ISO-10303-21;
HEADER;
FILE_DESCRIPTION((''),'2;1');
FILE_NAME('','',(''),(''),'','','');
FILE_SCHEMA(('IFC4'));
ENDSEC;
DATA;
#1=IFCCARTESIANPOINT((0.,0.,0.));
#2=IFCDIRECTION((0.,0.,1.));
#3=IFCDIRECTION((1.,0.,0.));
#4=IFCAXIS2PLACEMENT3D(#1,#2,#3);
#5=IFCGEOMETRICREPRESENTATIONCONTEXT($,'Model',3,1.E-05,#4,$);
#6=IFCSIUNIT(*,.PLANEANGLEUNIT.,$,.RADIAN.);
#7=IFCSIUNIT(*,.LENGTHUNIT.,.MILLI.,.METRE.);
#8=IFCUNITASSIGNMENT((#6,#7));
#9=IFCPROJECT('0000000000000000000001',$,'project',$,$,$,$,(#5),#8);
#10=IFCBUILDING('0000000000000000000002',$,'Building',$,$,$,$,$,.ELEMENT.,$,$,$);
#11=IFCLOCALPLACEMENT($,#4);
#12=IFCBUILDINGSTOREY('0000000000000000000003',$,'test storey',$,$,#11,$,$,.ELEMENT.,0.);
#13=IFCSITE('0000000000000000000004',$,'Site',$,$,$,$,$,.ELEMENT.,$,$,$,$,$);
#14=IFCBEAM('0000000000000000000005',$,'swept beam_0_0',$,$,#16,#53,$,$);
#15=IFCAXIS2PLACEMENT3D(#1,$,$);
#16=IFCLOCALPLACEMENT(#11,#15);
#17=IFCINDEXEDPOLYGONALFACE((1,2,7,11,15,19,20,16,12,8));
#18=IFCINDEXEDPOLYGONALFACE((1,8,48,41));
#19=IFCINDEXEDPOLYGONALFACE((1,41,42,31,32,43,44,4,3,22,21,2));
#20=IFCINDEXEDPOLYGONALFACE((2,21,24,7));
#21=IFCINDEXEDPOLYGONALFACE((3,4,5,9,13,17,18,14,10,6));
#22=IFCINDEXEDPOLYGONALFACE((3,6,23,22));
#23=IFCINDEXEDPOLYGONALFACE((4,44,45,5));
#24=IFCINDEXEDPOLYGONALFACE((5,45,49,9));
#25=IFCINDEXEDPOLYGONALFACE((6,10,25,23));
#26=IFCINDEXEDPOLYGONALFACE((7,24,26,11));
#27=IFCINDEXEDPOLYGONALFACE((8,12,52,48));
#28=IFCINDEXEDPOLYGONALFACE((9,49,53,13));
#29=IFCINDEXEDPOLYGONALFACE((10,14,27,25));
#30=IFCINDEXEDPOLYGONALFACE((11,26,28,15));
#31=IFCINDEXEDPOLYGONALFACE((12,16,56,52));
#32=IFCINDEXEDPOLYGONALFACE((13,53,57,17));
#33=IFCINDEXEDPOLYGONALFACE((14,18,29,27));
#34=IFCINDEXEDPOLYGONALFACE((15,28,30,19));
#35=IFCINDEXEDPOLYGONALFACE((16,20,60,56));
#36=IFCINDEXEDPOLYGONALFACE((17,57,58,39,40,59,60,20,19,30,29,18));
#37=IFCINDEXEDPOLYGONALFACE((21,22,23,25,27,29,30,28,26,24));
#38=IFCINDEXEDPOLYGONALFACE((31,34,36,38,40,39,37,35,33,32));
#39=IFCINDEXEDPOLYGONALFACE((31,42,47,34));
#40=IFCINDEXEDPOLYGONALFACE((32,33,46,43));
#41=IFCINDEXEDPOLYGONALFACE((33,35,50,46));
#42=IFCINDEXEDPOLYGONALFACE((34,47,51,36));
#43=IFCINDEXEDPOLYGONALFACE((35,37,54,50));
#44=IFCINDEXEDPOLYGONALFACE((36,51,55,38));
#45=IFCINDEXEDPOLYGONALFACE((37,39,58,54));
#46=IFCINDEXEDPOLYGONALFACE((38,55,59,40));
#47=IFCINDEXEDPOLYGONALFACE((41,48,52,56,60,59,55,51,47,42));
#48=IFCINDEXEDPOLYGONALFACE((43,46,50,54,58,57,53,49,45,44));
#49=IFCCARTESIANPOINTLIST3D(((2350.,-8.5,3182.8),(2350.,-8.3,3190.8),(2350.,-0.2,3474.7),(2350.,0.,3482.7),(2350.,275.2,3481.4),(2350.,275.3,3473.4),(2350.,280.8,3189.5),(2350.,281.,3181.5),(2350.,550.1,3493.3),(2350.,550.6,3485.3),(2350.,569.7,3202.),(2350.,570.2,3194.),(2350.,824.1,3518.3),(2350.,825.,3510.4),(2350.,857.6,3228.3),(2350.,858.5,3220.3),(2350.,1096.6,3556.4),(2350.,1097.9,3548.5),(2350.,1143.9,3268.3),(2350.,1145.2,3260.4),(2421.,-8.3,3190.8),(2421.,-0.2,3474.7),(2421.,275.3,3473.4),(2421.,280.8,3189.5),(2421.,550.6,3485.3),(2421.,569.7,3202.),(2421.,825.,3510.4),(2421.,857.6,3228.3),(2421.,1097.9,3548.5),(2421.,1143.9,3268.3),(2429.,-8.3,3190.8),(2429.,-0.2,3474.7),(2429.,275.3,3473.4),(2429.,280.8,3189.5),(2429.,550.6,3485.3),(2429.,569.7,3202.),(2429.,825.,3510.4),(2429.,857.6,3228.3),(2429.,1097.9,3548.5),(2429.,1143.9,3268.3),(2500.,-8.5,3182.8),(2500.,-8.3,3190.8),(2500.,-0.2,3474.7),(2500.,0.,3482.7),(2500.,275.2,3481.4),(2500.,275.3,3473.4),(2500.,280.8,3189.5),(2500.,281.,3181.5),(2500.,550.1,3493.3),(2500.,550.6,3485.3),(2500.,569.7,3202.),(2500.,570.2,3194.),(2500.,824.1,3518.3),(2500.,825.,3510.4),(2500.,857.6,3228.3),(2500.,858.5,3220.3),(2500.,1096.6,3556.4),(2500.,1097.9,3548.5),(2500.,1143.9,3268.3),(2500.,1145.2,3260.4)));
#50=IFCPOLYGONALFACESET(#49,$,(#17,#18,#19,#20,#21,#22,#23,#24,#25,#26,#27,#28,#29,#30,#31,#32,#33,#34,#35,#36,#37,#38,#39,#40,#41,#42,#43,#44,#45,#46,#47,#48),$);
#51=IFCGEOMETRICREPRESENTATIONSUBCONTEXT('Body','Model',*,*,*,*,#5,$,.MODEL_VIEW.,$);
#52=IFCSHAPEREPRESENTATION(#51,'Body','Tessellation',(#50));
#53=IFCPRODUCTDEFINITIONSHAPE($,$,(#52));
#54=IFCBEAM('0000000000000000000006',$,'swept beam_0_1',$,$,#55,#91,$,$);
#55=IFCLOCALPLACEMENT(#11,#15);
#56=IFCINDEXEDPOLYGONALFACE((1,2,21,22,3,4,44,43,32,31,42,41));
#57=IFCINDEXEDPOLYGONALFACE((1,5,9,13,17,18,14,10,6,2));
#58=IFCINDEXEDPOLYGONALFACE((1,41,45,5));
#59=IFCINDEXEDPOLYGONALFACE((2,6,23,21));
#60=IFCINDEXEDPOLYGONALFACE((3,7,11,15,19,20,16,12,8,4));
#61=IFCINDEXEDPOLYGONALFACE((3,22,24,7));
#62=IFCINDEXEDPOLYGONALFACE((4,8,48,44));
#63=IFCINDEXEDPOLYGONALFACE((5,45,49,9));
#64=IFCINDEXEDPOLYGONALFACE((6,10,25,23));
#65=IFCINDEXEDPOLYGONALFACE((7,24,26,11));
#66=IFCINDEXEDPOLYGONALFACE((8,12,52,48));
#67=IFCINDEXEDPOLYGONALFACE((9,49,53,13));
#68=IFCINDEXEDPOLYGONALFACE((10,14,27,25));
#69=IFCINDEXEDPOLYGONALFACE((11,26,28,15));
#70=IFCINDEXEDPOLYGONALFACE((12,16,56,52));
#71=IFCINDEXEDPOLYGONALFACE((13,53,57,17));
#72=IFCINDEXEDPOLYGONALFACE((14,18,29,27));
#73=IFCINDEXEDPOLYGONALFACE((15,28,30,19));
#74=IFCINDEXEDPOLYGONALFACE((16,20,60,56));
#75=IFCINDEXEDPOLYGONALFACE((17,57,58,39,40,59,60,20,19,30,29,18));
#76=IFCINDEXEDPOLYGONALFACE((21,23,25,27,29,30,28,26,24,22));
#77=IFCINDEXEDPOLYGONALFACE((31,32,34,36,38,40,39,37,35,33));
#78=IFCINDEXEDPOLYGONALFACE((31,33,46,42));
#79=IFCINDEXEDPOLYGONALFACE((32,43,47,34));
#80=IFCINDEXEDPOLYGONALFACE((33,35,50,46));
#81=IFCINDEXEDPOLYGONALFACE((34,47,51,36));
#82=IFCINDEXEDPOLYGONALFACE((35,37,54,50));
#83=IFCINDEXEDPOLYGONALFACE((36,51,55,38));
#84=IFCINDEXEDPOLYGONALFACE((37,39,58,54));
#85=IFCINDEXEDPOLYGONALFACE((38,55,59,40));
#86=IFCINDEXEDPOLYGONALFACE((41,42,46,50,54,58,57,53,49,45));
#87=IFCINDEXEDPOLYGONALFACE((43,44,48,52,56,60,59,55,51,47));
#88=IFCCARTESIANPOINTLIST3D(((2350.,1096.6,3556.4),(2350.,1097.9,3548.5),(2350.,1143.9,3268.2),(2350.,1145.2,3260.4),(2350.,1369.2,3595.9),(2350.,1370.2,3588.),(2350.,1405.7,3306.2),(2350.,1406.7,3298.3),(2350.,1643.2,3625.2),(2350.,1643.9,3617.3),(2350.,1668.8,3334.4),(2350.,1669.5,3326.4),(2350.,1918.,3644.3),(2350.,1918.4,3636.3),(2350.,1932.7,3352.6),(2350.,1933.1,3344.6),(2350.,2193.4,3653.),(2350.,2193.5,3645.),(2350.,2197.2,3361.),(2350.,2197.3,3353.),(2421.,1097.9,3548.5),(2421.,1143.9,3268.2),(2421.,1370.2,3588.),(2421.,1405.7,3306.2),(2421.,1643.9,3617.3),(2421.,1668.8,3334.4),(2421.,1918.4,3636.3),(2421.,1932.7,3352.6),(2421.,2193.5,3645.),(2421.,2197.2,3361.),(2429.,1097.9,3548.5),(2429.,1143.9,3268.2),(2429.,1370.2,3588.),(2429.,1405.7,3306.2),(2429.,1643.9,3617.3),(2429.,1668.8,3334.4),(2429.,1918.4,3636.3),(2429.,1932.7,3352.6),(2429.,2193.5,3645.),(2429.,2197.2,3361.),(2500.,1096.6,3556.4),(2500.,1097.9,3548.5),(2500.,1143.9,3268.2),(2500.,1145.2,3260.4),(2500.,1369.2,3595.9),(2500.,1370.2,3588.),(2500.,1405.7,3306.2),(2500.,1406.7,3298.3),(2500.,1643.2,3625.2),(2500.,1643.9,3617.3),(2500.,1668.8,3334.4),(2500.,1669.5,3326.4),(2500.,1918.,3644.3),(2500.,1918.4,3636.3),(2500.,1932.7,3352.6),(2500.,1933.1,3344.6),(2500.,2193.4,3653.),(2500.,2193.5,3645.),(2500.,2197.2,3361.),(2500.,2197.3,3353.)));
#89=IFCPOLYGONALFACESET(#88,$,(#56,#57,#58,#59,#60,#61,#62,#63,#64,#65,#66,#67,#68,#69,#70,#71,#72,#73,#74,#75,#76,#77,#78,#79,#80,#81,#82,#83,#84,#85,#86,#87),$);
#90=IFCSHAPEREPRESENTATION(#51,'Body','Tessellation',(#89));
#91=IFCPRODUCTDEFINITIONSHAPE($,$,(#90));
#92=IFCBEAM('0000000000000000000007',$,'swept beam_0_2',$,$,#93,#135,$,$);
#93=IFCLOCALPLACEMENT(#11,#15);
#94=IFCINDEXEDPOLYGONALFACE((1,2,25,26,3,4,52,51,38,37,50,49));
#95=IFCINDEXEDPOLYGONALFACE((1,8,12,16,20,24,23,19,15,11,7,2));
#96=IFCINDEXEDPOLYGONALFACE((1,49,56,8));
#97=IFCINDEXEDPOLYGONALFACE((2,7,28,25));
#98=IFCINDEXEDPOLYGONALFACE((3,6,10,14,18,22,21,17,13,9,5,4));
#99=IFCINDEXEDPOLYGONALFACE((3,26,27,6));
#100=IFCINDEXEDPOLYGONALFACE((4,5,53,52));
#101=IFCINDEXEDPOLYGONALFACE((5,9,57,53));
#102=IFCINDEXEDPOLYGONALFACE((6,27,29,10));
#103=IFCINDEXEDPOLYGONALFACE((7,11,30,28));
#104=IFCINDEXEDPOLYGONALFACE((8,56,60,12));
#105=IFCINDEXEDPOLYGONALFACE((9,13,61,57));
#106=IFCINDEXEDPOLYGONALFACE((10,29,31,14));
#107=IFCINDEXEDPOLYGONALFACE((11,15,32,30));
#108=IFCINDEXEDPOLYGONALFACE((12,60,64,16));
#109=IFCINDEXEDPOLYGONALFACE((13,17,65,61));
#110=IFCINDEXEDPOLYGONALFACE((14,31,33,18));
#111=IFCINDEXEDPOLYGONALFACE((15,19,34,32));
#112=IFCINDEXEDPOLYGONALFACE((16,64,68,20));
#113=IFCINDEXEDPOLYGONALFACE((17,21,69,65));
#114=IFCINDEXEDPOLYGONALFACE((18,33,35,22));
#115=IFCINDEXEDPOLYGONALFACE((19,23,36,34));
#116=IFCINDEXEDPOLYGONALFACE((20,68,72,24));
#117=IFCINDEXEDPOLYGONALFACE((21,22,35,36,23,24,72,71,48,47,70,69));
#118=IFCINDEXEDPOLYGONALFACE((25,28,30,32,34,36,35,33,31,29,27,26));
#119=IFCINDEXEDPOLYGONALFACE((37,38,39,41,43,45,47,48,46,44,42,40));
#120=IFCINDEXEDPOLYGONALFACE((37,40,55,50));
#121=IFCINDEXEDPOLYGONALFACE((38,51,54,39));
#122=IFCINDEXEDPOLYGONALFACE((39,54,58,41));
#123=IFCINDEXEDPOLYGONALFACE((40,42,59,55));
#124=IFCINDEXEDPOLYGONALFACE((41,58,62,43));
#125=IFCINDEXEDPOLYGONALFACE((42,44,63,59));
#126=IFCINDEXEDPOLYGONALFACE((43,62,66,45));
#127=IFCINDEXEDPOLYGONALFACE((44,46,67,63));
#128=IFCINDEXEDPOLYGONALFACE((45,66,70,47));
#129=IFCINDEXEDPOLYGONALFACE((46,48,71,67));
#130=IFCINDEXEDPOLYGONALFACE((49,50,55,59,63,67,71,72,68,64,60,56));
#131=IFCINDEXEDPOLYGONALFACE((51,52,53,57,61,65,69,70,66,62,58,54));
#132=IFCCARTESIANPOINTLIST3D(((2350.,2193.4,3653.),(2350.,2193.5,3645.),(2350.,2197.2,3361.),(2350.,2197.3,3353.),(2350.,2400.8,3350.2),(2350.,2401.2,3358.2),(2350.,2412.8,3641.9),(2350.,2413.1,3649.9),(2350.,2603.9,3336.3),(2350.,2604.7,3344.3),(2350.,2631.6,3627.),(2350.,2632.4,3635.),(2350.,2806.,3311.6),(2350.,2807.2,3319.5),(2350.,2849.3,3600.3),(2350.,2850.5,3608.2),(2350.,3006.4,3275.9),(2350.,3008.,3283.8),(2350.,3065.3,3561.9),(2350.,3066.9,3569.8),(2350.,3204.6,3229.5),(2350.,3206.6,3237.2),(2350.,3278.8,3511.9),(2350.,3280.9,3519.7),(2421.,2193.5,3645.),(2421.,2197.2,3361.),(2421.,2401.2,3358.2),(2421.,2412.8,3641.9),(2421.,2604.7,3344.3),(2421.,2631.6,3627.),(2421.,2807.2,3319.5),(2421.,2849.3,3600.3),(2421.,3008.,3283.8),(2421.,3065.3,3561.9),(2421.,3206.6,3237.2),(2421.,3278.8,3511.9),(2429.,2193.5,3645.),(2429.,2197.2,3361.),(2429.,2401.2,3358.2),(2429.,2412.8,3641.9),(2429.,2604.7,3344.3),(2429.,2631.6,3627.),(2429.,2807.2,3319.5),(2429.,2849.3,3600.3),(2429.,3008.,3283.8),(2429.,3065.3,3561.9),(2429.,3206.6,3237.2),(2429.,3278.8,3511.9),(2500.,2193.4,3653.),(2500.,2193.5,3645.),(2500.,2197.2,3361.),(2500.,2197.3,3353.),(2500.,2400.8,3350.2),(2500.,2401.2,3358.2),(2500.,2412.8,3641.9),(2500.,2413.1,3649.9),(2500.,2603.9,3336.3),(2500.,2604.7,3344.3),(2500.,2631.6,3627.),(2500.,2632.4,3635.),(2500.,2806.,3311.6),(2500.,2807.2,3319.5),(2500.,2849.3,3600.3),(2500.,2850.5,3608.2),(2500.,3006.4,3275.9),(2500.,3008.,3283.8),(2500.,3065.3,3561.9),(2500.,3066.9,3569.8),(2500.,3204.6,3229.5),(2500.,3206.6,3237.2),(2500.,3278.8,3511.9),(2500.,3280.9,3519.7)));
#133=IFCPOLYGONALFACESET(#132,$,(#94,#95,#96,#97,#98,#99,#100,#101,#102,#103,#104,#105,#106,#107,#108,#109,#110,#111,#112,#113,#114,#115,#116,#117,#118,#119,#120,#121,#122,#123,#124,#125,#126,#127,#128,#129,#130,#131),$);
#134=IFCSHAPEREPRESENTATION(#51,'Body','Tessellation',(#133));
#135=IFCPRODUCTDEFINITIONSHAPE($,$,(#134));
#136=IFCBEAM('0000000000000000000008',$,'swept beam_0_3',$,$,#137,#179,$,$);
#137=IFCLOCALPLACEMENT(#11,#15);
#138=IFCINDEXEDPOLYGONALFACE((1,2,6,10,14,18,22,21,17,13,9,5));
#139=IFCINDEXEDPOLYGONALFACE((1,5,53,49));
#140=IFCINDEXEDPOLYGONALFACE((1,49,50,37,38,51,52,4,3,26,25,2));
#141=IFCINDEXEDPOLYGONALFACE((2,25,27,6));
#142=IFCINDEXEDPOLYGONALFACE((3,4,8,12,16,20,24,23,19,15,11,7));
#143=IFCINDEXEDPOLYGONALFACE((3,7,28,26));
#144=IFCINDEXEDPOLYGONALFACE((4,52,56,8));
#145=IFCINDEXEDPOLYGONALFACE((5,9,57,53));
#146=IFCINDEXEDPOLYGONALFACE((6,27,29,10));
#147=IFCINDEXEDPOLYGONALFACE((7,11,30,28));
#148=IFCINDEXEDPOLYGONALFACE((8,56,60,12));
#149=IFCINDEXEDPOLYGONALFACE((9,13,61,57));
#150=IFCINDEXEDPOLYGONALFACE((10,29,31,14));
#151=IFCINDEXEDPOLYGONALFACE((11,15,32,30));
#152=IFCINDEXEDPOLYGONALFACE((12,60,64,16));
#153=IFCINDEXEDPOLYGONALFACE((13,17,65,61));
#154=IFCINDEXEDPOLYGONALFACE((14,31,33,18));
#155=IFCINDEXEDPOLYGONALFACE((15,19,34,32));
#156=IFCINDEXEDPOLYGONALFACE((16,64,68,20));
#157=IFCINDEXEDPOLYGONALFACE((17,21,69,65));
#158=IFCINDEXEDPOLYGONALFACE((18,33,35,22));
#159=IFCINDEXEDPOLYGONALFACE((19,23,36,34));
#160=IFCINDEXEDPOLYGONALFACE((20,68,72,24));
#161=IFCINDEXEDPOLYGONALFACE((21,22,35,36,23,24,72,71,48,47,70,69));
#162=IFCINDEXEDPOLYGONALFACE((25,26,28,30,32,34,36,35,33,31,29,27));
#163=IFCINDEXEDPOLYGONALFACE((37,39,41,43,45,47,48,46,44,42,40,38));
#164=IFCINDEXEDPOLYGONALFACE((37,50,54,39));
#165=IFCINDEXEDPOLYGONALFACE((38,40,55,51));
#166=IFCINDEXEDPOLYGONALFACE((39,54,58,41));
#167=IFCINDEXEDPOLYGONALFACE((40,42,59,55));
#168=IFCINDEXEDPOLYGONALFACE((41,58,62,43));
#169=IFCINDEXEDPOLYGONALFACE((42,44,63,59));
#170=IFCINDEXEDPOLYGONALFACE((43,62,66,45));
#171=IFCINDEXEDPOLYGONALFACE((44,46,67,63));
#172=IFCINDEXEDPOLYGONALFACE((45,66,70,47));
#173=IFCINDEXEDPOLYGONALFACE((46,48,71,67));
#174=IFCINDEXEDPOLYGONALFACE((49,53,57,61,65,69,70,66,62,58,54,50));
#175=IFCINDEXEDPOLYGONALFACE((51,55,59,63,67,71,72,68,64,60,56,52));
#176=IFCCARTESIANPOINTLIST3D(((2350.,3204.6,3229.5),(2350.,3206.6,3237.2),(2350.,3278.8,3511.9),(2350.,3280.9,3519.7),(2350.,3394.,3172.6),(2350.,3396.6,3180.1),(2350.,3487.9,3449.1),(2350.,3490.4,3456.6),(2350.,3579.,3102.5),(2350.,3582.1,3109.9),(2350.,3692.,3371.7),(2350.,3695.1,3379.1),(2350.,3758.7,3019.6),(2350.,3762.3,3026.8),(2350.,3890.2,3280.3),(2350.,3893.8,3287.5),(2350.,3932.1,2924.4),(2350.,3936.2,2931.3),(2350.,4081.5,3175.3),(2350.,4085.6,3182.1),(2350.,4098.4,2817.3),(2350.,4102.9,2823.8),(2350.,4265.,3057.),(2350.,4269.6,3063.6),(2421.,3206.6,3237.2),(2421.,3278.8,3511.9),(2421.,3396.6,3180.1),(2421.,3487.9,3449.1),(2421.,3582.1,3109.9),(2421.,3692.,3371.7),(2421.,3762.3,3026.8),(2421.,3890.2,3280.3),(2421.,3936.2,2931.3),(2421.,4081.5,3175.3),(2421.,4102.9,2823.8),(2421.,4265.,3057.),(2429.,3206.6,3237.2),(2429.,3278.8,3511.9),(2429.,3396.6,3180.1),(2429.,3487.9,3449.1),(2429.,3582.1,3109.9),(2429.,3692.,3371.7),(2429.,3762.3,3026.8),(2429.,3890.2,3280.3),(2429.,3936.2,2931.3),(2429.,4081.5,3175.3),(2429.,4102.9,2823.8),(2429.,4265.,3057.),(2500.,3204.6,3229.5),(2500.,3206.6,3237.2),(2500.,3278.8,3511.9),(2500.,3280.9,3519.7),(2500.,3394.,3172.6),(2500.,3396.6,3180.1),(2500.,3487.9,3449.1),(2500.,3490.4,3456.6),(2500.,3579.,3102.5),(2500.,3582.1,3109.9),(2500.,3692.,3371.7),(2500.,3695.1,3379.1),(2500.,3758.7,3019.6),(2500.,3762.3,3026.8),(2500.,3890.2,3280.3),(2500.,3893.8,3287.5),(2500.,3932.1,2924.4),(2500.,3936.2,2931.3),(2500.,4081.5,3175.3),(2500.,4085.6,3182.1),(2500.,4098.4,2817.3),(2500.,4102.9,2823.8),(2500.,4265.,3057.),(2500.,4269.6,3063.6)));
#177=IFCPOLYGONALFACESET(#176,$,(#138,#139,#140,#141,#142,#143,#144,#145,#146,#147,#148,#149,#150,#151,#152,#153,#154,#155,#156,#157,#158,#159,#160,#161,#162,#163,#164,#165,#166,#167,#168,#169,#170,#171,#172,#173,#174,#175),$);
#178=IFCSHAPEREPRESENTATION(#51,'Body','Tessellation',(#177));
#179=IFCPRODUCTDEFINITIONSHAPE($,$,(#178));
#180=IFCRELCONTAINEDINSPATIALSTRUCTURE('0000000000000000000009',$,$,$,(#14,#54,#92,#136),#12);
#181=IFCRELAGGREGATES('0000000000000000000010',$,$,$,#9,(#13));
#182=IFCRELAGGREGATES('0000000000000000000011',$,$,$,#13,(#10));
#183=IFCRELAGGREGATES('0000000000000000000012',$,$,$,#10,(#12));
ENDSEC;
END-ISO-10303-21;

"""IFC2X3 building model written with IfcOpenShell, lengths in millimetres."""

from ifc_helpers import new_model, entity, si_unit, origin_with_axes, place, context, subcontext, project, spatial, element, save


model = new_model("IFC2X3")

# Units and contexts
model_context = context("Model", 3, precision=1e-05, world=origin_with_axes())
body_context = subcontext(model_context, "Body", "Model", "MODEL_VIEW")
ifc_project = project(units=[si_unit("PLANEANGLEUNIT", "RADIAN"), si_unit("LENGTHUNIT", "METRE", prefix="MILLI")], contexts=[model_context])

# Site, building, storey
site = spatial("IfcSite", under=ifc_project, Name="Site", CompositionType="ELEMENT")
building = spatial("IfcBuilding", under=site, Name="Building", CompositionType="ELEMENT")
storey_placement = place(None, origin_with_axes())
storey = spatial("IfcBuildingStorey", under=building, at=storey_placement, Name="test storey", CompositionType="ELEMENT", Elevation=0.0)

# Beams
beam_1_placement = place(storey_placement, origin_with_axes())
element("IfcBeam", 1, at=beam_1_placement, inside=storey, Name="swept beam_0_0", context=body_context, shape_type="SweptSolid", body=[
    entity("IfcRevolvedAreaSolid", entity("IfcArbitraryClosedProfileDef", "AREA", None, entity("IfcPolyline", [entity("IfcCartesianPoint", [292.0, 0.0]), entity("IfcCartesianPoint", [292.0, -71.0]), entity("IfcCartesianPoint", [8.0, -71.0]), entity("IfcCartesianPoint", [8.0, 0.0]), entity("IfcCartesianPoint", [0.0, 0.0]), entity("IfcCartesianPoint", [0.0, -150.0]), entity("IfcCartesianPoint", [8.0, -150.0]), entity("IfcCartesianPoint", [8.0, -79.0]), entity("IfcCartesianPoint", [292.0, -79.0]), entity("IfcCartesianPoint", [292.0, -150.0]), entity("IfcCartesianPoint", [300.0, -150.0]), entity("IfcCartesianPoint", [300.0, 0.0]), entity("IfcCartesianPoint", [292.0, 0.0])])), entity("IfcAxis2Placement3D", entity("IfcCartesianPoint", [2500.0, 0.0, 3482.7]), entity("IfcDirection", [0.0, -0.9996, 0.0284]), entity("IfcDirection", [0.0, -0.0284, -0.9996])), entity("IfcAxis1Placement", entity("IfcCartesianPoint", [-5757.9, 0.0, 0.0]), entity("IfcDirection", [0.0, 1.0, 0.0])), 0.191172),
])
beam_2_placement = place(storey_placement, origin_with_axes())
element("IfcBeam", 2, at=beam_2_placement, inside=storey, Name="swept beam_0_1", context=body_context, shape_type="SweptSolid", body=[
    entity("IfcRevolvedAreaSolid", entity("IfcArbitraryClosedProfileDef", "AREA", None, entity("IfcPolyline", [entity("IfcCartesianPoint", [-292.0, 0.0]), entity("IfcCartesianPoint", [-292.0, 71.0]), entity("IfcCartesianPoint", [-8.0, 71.0]), entity("IfcCartesianPoint", [-8.0, 0.0]), entity("IfcCartesianPoint", [0.0, 0.0]), entity("IfcCartesianPoint", [0.0, 150.0]), entity("IfcCartesianPoint", [-8.0, 150.0]), entity("IfcCartesianPoint", [-8.0, 79.0]), entity("IfcCartesianPoint", [-292.0, 79.0]), entity("IfcCartesianPoint", [-292.0, 150.0]), entity("IfcCartesianPoint", [-300.0, 150.0]), entity("IfcCartesianPoint", [-300.0, 0.0]), entity("IfcCartesianPoint", [-292.0, 0.0])])), entity("IfcAxis2Placement3D", entity("IfcCartesianPoint", [2500.0, 1096.6, 3556.4]), entity("IfcDirection", [0.0, -0.9868, -0.162]), entity("IfcDirection", [0.0, -0.162, 0.9868])), entity("IfcAxis1Placement", entity("IfcCartesianPoint", [-7360.2, 0.0, 0.0]), entity("IfcDirection", [0.0, 1.0, 0.0])), 0.149732),
])
beam_3_placement = place(storey_placement, origin_with_axes())
element("IfcBeam", 3, at=beam_3_placement, inside=storey, Name="swept beam_0_2", context=body_context, shape_type="SweptSolid", body=[
    entity("IfcRevolvedAreaSolid", entity("IfcArbitraryClosedProfileDef", "AREA", None, entity("IfcPolyline", [entity("IfcCartesianPoint", [-292.0, 0.0]), entity("IfcCartesianPoint", [-292.0, 71.0]), entity("IfcCartesianPoint", [-8.0, 71.0]), entity("IfcCartesianPoint", [-8.0, 0.0]), entity("IfcCartesianPoint", [0.0, 0.0]), entity("IfcCartesianPoint", [0.0, 150.0]), entity("IfcCartesianPoint", [-8.0, 150.0]), entity("IfcCartesianPoint", [-8.0, 79.0]), entity("IfcCartesianPoint", [-292.0, 79.0]), entity("IfcCartesianPoint", [-292.0, 150.0]), entity("IfcCartesianPoint", [-300.0, 150.0]), entity("IfcCartesianPoint", [-300.0, 0.0]), entity("IfcCartesianPoint", [-292.0, 0.0])])), entity("IfcAxis2Placement3D", entity("IfcCartesianPoint", [2500.0, 2193.4, 3653.0]), entity("IfcDirection", [0.0, -0.9999, -0.013]), entity("IfcDirection", [0.0, -0.013, 0.9999])), entity("IfcAxis1Placement", entity("IfcCartesianPoint", [-4069.9, 0.0, 0.0]), entity("IfcDirection", [0.0, 1.0, 0.0])), 0.270029),
])
beam_4_placement = place(storey_placement, origin_with_axes())
element("IfcBeam", 4, at=beam_4_placement, inside=storey, Name="swept beam_0_3", context=body_context, shape_type="SweptSolid", body=[
    entity("IfcRevolvedAreaSolid", entity("IfcArbitraryClosedProfileDef", "AREA", None, entity("IfcPolyline", [entity("IfcCartesianPoint", [-292.0, 0.0]), entity("IfcCartesianPoint", [-292.0, 71.0]), entity("IfcCartesianPoint", [-8.0, 71.0]), entity("IfcCartesianPoint", [-8.0, 0.0]), entity("IfcCartesianPoint", [0.0, 0.0]), entity("IfcCartesianPoint", [0.0, 150.0]), entity("IfcCartesianPoint", [-8.0, 150.0]), entity("IfcCartesianPoint", [-8.0, 79.0]), entity("IfcCartesianPoint", [-292.0, 79.0]), entity("IfcCartesianPoint", [-292.0, 150.0]), entity("IfcCartesianPoint", [-300.0, 150.0]), entity("IfcCartesianPoint", [-300.0, 0.0]), entity("IfcCartesianPoint", [-292.0, 0.0])])), entity("IfcAxis2Placement3D", entity("IfcCartesianPoint", [2500.0, 3280.9, 3519.7]), entity("IfcDirection", [0.0, -0.9671, 0.2542]), entity("IfcDirection", [0.0, 0.2542, 0.9671])), entity("IfcAxis1Placement", entity("IfcCartesianPoint", [-3124.3, 0.0, 0.0]), entity("IfcDirection", [0.0, 1.0, 0.0])), 0.350282),
])

save(model, "model.ifc")
